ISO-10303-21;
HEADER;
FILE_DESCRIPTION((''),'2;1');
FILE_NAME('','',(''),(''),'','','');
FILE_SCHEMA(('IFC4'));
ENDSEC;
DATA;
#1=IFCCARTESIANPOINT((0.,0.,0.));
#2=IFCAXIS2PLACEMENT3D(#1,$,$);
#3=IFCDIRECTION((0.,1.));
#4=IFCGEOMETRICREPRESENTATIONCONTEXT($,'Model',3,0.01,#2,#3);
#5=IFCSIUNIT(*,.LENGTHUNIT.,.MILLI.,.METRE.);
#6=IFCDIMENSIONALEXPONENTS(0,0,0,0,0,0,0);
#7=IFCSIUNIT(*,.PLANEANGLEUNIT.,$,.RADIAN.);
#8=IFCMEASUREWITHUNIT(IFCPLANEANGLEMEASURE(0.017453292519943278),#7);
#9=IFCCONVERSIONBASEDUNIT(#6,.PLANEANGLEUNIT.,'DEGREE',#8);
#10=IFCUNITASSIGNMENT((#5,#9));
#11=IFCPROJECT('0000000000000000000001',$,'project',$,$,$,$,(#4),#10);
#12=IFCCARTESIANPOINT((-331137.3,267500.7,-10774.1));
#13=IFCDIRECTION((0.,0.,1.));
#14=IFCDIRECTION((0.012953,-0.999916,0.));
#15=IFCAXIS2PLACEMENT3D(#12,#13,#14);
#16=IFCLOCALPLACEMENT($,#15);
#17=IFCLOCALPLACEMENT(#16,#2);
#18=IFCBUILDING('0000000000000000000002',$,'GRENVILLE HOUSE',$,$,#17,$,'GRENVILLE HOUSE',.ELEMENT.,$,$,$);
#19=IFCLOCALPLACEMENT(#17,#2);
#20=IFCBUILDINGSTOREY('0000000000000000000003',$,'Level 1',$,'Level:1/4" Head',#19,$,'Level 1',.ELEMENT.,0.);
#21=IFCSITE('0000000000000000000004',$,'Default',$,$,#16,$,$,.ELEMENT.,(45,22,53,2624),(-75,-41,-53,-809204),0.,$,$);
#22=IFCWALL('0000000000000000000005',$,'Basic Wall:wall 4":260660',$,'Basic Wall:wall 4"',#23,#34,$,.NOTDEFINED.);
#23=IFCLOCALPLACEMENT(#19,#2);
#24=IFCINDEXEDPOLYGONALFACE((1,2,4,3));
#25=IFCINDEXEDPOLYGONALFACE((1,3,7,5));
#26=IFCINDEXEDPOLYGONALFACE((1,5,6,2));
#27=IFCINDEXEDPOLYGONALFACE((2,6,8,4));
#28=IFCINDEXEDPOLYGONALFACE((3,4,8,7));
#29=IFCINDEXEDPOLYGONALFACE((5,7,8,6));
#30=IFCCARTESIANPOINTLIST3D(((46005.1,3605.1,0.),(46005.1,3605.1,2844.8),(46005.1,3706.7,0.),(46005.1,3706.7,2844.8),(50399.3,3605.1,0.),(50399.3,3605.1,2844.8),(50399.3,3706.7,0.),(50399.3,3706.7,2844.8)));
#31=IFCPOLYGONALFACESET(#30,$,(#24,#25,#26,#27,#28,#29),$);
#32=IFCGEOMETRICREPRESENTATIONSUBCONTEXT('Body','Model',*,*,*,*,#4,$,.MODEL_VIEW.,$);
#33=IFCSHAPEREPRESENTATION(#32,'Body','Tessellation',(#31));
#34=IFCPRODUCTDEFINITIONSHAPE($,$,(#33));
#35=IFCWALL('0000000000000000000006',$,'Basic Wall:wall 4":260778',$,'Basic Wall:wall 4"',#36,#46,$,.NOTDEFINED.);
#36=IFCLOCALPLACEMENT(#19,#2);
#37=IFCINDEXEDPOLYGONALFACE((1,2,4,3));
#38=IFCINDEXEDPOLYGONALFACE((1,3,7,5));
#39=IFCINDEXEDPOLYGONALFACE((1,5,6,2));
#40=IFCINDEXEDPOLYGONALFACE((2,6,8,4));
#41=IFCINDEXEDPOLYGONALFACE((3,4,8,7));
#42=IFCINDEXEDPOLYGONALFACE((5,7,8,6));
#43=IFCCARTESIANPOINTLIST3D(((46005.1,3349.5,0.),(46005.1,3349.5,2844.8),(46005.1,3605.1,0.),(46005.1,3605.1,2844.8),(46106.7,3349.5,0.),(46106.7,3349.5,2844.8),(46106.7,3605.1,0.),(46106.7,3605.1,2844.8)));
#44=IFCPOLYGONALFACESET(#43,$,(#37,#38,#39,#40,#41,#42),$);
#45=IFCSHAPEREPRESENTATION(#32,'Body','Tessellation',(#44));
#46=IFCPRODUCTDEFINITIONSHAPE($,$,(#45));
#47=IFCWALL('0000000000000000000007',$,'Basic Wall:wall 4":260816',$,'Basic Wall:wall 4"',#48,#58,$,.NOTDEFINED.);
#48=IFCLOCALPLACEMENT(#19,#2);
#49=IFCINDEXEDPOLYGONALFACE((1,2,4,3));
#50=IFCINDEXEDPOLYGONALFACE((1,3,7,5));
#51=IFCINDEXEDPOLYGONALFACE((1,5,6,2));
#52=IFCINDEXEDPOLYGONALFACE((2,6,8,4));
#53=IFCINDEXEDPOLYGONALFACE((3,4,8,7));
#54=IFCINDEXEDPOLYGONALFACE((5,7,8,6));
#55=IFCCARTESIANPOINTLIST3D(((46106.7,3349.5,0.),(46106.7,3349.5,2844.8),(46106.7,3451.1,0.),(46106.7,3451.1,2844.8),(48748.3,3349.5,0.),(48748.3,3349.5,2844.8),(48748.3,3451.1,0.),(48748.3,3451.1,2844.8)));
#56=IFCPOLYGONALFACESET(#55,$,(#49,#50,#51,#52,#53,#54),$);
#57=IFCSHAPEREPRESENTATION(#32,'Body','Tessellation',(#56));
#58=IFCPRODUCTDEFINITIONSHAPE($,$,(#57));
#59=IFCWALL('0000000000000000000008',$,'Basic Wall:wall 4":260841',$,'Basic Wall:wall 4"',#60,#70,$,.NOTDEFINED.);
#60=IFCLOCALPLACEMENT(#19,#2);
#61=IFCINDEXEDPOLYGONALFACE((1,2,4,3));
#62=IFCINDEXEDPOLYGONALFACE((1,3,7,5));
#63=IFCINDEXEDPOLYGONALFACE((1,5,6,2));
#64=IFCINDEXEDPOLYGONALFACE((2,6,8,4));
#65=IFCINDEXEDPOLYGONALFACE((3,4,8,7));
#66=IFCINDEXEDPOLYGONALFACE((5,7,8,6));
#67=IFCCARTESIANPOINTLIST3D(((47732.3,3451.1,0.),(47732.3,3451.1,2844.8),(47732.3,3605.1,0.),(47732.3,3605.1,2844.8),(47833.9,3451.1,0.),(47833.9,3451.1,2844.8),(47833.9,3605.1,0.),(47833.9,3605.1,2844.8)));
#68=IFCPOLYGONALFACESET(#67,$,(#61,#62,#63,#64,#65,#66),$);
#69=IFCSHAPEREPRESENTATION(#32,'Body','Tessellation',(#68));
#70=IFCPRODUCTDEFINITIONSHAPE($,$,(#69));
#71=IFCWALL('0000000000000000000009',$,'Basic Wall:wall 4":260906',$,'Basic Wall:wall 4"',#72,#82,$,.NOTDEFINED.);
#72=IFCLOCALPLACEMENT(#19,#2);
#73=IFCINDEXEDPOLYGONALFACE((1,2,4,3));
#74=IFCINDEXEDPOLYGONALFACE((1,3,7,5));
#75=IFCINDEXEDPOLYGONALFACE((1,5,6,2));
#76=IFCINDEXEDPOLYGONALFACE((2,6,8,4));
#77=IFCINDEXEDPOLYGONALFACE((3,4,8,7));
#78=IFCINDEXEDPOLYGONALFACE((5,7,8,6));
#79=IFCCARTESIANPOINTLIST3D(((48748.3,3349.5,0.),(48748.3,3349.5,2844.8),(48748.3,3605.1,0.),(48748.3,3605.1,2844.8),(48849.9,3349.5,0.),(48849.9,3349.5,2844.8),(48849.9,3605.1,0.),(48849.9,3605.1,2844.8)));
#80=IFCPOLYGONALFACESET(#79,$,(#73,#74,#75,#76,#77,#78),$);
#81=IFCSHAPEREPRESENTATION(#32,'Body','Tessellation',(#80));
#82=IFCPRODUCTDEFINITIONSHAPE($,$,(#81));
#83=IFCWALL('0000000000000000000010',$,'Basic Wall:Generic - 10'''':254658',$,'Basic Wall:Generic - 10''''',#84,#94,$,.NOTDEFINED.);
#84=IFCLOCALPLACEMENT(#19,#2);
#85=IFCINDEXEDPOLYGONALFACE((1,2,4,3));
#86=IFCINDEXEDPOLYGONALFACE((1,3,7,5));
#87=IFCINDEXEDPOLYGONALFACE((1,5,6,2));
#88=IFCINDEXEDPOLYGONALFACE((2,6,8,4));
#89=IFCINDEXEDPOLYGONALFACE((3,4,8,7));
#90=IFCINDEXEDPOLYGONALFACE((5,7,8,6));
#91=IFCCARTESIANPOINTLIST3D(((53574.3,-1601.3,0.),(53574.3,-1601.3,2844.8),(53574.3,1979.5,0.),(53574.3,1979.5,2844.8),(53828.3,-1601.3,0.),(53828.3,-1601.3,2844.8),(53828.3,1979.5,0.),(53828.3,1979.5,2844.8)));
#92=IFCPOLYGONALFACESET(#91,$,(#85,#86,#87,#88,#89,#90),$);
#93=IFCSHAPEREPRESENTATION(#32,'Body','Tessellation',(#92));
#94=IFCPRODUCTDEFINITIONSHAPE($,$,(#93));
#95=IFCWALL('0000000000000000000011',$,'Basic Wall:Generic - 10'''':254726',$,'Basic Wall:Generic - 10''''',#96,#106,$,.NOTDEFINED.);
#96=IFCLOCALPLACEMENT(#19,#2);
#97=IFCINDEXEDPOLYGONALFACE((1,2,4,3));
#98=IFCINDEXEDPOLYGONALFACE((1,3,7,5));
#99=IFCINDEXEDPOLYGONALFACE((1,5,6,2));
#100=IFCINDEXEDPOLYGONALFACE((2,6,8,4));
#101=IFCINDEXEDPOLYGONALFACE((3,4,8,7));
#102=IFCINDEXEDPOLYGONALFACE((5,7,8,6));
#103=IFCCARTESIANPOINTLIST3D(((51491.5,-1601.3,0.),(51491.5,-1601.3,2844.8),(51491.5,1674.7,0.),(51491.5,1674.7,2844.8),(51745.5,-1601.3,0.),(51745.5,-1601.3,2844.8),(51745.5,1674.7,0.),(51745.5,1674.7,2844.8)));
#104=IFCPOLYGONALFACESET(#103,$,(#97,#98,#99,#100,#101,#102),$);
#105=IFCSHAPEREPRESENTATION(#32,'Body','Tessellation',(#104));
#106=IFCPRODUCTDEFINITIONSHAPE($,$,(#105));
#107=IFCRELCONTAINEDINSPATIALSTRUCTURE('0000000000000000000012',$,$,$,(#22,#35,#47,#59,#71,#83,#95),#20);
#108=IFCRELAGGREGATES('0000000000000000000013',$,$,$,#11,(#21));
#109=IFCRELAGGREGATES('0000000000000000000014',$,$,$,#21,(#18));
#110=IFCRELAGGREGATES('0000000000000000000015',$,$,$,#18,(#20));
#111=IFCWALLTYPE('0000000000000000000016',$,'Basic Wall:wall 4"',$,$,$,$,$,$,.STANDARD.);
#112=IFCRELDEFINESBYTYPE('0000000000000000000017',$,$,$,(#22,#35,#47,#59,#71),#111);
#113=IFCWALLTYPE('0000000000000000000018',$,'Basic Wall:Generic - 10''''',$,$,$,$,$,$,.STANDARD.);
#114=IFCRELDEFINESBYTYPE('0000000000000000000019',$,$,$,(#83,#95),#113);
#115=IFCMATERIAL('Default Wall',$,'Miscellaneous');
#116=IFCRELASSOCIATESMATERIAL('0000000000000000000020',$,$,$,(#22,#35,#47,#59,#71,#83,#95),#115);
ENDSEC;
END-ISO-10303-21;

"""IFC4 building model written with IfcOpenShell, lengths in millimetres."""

from ifc_helpers import new_model, entity, si_unit, converted_unit, direction, frame, origin, place, context, subcontext, project, spatial, indexed_curve, outline, extrude, material, type_object, element, save


model = new_model("IFC4")

# Units and contexts
model_context = context("Model", 3, precision=0.01, world=origin(), true_north=direction((0.0, 1.0)))
body_context = subcontext(model_context, "Body", "Model", "MODEL_VIEW")
ifc_project = project(units=[si_unit("LENGTHUNIT", "METRE", prefix="MILLI"), converted_unit("PLANEANGLEUNIT", "DEGREE", entity("IfcPlaneAngleMeasure", 0.017453292519943278), si_unit("PLANEANGLEUNIT", "RADIAN"), dimensions=[0, 0, 0, 0, 0, 0, 0])], contexts=[model_context])

# Site, building, storey
site_placement = place(None, frame((-331137.3, 267500.7, -10774.1), z_axis=(0.0, 0.0, 1.0), x_axis=(0.012953, -0.999916, 0.0)))
site = spatial("IfcSite", under=ifc_project, at=site_placement, Name="Default", CompositionType="ELEMENT", RefLatitude=(45, 22, 53, 2624), RefLongitude=(-75, -41, -53, -809204), RefElevation=0.0)
building_placement = place(site_placement, origin())
building = spatial("IfcBuilding", under=site, at=building_placement, Name="GRENVILLE HOUSE", LongName="GRENVILLE HOUSE", CompositionType="ELEMENT")
storey_placement = place(building_placement, origin())
storey = spatial("IfcBuildingStorey", under=building, at=storey_placement, Name="Level 1", ObjectType="Level:1/4\" Head", LongName="Level 1", CompositionType="ELEMENT", Elevation=0.0)

# Walls
ifc_material_1 = material(Name="Default Wall", Category="Miscellaneous")
wall_type_1 = type_object("IfcWallType", Name="Basic Wall:wall 4\"", PredefinedType="STANDARD")
wall_1_placement = place(storey_placement, frame((46005.1, 3655.9, 0.0)))
element("IfcWall", 1, at=wall_1_placement, inside=storey, type_object=wall_type_1, material=ifc_material_1, Name="Basic Wall:wall 4\":260660", ObjectType="Basic Wall:wall 4\"", PredefinedType="NOTDEFINED", context=body_context, shape_type="SweptSolid", body=[
    extrude(outline(indexed_curve([(4394.2, 50.8), (0.0, 50.8), (0.0, -50.8), (4394.2, -50.8), (4394.2, 50.8)], self_intersect=False)), origin(), (0.0, 0.0, 1.0), 2844.8),
])
wall_2_placement = place(storey_placement, frame((46055.9, 3605.1, 0.0), z_axis=(0.0, 0.0, 1.0), x_axis=(0.0, -1.0, 0.0)))
element("IfcWall", 2, at=wall_2_placement, inside=storey, type_object=wall_type_1, material=ifc_material_1, Name="Basic Wall:wall 4\":260778", ObjectType="Basic Wall:wall 4\"", PredefinedType="NOTDEFINED", context=body_context, shape_type="SweptSolid", body=[
    extrude(outline(indexed_curve([(255.6, 50.8), (0.0, 50.8), (0.0, -50.8), (255.6, -50.8), (255.6, 50.8)], self_intersect=False)), origin(), (0.0, 0.0, 1.0), 2844.8),
])
wall_3_placement = place(storey_placement, frame((46106.7, 3400.3, 0.0)))
element("IfcWall", 3, at=wall_3_placement, inside=storey, type_object=wall_type_1, material=ifc_material_1, Name="Basic Wall:wall 4\":260816", ObjectType="Basic Wall:wall 4\"", PredefinedType="NOTDEFINED", context=body_context, shape_type="SweptSolid", body=[
    extrude(outline(indexed_curve([(2641.6, 50.8), (0.0, 50.8), (0.0, -50.8), (2641.6, -50.8), (2641.6, 50.8)], self_intersect=False)), origin(), (0.0, 0.0, 1.0), 2844.8),
])
wall_4_placement = place(storey_placement, frame((47783.1, 3451.1, 0.0), z_axis=(0.0, 0.0, 1.0), x_axis=(0.0, 1.0, 0.0)))
element("IfcWall", 4, at=wall_4_placement, inside=storey, type_object=wall_type_1, material=ifc_material_1, Name="Basic Wall:wall 4\":260841", ObjectType="Basic Wall:wall 4\"", PredefinedType="NOTDEFINED", context=body_context, shape_type="SweptSolid", body=[
    extrude(outline(indexed_curve([(154.0, 50.8), (0.0, 50.8), (0.0, -50.8), (154.0, -50.8), (154.0, 50.8)], self_intersect=False)), origin(), (0.0, 0.0, 1.0), 2844.8),
])
wall_5_placement = place(storey_placement, frame((48799.1, 3349.5, 0.0), z_axis=(0.0, 0.0, 1.0), x_axis=(0.0, 1.0, 0.0)))
element("IfcWall", 5, at=wall_5_placement, inside=storey, type_object=wall_type_1, material=ifc_material_1, Name="Basic Wall:wall 4\":260906", ObjectType="Basic Wall:wall 4\"", PredefinedType="NOTDEFINED", context=body_context, shape_type="SweptSolid", body=[
    extrude(outline(indexed_curve([(255.6, 50.8), (0.0, 50.8), (0.0, -50.8), (255.6, -50.8), (255.6, 50.8)], self_intersect=False)), origin(), (0.0, 0.0, 1.0), 2844.8),
])
wall_type_2 = type_object("IfcWallType", Name="Basic Wall:Generic - 10''", PredefinedType="STANDARD")
wall_6_placement = place(storey_placement, frame((53701.3, 1979.5, 0.0), z_axis=(0.0, 0.0, 1.0), x_axis=(0.0, -1.0, 0.0)))
element("IfcWall", 6, at=wall_6_placement, inside=storey, type_object=wall_type_2, material=ifc_material_1, Name="Basic Wall:Generic - 10'':254658", ObjectType="Basic Wall:Generic - 10''", PredefinedType="NOTDEFINED", context=body_context, shape_type="SweptSolid", body=[
    extrude(outline(indexed_curve([(3580.9, 127.0), (0.0, 127.0), (0.0, -127.0), (3580.9, -127.0), (3580.9, 127.0)], self_intersect=False)), origin(), (0.0, 0.0, 1.0), 2844.8),
])
wall_7_placement = place(storey_placement, frame((51618.5, 1674.7, 0.0), z_axis=(0.0, 0.0, 1.0), x_axis=(0.0, -1.0, 0.0)))
element("IfcWall", 7, at=wall_7_placement, inside=storey, type_object=wall_type_2, material=ifc_material_1, Name="Basic Wall:Generic - 10'':254726", ObjectType="Basic Wall:Generic - 10''", PredefinedType="NOTDEFINED", context=body_context, shape_type="SweptSolid", body=[
    extrude(outline(indexed_curve([(3276.1, 127.0), (0.0, 127.0), (0.0, -127.0), (3276.1, -127.0), (3276.1, 127.0)], self_intersect=False)), origin(), (0.0, 0.0, 1.0), 2844.8),
])

save(model, "model.ifc")
